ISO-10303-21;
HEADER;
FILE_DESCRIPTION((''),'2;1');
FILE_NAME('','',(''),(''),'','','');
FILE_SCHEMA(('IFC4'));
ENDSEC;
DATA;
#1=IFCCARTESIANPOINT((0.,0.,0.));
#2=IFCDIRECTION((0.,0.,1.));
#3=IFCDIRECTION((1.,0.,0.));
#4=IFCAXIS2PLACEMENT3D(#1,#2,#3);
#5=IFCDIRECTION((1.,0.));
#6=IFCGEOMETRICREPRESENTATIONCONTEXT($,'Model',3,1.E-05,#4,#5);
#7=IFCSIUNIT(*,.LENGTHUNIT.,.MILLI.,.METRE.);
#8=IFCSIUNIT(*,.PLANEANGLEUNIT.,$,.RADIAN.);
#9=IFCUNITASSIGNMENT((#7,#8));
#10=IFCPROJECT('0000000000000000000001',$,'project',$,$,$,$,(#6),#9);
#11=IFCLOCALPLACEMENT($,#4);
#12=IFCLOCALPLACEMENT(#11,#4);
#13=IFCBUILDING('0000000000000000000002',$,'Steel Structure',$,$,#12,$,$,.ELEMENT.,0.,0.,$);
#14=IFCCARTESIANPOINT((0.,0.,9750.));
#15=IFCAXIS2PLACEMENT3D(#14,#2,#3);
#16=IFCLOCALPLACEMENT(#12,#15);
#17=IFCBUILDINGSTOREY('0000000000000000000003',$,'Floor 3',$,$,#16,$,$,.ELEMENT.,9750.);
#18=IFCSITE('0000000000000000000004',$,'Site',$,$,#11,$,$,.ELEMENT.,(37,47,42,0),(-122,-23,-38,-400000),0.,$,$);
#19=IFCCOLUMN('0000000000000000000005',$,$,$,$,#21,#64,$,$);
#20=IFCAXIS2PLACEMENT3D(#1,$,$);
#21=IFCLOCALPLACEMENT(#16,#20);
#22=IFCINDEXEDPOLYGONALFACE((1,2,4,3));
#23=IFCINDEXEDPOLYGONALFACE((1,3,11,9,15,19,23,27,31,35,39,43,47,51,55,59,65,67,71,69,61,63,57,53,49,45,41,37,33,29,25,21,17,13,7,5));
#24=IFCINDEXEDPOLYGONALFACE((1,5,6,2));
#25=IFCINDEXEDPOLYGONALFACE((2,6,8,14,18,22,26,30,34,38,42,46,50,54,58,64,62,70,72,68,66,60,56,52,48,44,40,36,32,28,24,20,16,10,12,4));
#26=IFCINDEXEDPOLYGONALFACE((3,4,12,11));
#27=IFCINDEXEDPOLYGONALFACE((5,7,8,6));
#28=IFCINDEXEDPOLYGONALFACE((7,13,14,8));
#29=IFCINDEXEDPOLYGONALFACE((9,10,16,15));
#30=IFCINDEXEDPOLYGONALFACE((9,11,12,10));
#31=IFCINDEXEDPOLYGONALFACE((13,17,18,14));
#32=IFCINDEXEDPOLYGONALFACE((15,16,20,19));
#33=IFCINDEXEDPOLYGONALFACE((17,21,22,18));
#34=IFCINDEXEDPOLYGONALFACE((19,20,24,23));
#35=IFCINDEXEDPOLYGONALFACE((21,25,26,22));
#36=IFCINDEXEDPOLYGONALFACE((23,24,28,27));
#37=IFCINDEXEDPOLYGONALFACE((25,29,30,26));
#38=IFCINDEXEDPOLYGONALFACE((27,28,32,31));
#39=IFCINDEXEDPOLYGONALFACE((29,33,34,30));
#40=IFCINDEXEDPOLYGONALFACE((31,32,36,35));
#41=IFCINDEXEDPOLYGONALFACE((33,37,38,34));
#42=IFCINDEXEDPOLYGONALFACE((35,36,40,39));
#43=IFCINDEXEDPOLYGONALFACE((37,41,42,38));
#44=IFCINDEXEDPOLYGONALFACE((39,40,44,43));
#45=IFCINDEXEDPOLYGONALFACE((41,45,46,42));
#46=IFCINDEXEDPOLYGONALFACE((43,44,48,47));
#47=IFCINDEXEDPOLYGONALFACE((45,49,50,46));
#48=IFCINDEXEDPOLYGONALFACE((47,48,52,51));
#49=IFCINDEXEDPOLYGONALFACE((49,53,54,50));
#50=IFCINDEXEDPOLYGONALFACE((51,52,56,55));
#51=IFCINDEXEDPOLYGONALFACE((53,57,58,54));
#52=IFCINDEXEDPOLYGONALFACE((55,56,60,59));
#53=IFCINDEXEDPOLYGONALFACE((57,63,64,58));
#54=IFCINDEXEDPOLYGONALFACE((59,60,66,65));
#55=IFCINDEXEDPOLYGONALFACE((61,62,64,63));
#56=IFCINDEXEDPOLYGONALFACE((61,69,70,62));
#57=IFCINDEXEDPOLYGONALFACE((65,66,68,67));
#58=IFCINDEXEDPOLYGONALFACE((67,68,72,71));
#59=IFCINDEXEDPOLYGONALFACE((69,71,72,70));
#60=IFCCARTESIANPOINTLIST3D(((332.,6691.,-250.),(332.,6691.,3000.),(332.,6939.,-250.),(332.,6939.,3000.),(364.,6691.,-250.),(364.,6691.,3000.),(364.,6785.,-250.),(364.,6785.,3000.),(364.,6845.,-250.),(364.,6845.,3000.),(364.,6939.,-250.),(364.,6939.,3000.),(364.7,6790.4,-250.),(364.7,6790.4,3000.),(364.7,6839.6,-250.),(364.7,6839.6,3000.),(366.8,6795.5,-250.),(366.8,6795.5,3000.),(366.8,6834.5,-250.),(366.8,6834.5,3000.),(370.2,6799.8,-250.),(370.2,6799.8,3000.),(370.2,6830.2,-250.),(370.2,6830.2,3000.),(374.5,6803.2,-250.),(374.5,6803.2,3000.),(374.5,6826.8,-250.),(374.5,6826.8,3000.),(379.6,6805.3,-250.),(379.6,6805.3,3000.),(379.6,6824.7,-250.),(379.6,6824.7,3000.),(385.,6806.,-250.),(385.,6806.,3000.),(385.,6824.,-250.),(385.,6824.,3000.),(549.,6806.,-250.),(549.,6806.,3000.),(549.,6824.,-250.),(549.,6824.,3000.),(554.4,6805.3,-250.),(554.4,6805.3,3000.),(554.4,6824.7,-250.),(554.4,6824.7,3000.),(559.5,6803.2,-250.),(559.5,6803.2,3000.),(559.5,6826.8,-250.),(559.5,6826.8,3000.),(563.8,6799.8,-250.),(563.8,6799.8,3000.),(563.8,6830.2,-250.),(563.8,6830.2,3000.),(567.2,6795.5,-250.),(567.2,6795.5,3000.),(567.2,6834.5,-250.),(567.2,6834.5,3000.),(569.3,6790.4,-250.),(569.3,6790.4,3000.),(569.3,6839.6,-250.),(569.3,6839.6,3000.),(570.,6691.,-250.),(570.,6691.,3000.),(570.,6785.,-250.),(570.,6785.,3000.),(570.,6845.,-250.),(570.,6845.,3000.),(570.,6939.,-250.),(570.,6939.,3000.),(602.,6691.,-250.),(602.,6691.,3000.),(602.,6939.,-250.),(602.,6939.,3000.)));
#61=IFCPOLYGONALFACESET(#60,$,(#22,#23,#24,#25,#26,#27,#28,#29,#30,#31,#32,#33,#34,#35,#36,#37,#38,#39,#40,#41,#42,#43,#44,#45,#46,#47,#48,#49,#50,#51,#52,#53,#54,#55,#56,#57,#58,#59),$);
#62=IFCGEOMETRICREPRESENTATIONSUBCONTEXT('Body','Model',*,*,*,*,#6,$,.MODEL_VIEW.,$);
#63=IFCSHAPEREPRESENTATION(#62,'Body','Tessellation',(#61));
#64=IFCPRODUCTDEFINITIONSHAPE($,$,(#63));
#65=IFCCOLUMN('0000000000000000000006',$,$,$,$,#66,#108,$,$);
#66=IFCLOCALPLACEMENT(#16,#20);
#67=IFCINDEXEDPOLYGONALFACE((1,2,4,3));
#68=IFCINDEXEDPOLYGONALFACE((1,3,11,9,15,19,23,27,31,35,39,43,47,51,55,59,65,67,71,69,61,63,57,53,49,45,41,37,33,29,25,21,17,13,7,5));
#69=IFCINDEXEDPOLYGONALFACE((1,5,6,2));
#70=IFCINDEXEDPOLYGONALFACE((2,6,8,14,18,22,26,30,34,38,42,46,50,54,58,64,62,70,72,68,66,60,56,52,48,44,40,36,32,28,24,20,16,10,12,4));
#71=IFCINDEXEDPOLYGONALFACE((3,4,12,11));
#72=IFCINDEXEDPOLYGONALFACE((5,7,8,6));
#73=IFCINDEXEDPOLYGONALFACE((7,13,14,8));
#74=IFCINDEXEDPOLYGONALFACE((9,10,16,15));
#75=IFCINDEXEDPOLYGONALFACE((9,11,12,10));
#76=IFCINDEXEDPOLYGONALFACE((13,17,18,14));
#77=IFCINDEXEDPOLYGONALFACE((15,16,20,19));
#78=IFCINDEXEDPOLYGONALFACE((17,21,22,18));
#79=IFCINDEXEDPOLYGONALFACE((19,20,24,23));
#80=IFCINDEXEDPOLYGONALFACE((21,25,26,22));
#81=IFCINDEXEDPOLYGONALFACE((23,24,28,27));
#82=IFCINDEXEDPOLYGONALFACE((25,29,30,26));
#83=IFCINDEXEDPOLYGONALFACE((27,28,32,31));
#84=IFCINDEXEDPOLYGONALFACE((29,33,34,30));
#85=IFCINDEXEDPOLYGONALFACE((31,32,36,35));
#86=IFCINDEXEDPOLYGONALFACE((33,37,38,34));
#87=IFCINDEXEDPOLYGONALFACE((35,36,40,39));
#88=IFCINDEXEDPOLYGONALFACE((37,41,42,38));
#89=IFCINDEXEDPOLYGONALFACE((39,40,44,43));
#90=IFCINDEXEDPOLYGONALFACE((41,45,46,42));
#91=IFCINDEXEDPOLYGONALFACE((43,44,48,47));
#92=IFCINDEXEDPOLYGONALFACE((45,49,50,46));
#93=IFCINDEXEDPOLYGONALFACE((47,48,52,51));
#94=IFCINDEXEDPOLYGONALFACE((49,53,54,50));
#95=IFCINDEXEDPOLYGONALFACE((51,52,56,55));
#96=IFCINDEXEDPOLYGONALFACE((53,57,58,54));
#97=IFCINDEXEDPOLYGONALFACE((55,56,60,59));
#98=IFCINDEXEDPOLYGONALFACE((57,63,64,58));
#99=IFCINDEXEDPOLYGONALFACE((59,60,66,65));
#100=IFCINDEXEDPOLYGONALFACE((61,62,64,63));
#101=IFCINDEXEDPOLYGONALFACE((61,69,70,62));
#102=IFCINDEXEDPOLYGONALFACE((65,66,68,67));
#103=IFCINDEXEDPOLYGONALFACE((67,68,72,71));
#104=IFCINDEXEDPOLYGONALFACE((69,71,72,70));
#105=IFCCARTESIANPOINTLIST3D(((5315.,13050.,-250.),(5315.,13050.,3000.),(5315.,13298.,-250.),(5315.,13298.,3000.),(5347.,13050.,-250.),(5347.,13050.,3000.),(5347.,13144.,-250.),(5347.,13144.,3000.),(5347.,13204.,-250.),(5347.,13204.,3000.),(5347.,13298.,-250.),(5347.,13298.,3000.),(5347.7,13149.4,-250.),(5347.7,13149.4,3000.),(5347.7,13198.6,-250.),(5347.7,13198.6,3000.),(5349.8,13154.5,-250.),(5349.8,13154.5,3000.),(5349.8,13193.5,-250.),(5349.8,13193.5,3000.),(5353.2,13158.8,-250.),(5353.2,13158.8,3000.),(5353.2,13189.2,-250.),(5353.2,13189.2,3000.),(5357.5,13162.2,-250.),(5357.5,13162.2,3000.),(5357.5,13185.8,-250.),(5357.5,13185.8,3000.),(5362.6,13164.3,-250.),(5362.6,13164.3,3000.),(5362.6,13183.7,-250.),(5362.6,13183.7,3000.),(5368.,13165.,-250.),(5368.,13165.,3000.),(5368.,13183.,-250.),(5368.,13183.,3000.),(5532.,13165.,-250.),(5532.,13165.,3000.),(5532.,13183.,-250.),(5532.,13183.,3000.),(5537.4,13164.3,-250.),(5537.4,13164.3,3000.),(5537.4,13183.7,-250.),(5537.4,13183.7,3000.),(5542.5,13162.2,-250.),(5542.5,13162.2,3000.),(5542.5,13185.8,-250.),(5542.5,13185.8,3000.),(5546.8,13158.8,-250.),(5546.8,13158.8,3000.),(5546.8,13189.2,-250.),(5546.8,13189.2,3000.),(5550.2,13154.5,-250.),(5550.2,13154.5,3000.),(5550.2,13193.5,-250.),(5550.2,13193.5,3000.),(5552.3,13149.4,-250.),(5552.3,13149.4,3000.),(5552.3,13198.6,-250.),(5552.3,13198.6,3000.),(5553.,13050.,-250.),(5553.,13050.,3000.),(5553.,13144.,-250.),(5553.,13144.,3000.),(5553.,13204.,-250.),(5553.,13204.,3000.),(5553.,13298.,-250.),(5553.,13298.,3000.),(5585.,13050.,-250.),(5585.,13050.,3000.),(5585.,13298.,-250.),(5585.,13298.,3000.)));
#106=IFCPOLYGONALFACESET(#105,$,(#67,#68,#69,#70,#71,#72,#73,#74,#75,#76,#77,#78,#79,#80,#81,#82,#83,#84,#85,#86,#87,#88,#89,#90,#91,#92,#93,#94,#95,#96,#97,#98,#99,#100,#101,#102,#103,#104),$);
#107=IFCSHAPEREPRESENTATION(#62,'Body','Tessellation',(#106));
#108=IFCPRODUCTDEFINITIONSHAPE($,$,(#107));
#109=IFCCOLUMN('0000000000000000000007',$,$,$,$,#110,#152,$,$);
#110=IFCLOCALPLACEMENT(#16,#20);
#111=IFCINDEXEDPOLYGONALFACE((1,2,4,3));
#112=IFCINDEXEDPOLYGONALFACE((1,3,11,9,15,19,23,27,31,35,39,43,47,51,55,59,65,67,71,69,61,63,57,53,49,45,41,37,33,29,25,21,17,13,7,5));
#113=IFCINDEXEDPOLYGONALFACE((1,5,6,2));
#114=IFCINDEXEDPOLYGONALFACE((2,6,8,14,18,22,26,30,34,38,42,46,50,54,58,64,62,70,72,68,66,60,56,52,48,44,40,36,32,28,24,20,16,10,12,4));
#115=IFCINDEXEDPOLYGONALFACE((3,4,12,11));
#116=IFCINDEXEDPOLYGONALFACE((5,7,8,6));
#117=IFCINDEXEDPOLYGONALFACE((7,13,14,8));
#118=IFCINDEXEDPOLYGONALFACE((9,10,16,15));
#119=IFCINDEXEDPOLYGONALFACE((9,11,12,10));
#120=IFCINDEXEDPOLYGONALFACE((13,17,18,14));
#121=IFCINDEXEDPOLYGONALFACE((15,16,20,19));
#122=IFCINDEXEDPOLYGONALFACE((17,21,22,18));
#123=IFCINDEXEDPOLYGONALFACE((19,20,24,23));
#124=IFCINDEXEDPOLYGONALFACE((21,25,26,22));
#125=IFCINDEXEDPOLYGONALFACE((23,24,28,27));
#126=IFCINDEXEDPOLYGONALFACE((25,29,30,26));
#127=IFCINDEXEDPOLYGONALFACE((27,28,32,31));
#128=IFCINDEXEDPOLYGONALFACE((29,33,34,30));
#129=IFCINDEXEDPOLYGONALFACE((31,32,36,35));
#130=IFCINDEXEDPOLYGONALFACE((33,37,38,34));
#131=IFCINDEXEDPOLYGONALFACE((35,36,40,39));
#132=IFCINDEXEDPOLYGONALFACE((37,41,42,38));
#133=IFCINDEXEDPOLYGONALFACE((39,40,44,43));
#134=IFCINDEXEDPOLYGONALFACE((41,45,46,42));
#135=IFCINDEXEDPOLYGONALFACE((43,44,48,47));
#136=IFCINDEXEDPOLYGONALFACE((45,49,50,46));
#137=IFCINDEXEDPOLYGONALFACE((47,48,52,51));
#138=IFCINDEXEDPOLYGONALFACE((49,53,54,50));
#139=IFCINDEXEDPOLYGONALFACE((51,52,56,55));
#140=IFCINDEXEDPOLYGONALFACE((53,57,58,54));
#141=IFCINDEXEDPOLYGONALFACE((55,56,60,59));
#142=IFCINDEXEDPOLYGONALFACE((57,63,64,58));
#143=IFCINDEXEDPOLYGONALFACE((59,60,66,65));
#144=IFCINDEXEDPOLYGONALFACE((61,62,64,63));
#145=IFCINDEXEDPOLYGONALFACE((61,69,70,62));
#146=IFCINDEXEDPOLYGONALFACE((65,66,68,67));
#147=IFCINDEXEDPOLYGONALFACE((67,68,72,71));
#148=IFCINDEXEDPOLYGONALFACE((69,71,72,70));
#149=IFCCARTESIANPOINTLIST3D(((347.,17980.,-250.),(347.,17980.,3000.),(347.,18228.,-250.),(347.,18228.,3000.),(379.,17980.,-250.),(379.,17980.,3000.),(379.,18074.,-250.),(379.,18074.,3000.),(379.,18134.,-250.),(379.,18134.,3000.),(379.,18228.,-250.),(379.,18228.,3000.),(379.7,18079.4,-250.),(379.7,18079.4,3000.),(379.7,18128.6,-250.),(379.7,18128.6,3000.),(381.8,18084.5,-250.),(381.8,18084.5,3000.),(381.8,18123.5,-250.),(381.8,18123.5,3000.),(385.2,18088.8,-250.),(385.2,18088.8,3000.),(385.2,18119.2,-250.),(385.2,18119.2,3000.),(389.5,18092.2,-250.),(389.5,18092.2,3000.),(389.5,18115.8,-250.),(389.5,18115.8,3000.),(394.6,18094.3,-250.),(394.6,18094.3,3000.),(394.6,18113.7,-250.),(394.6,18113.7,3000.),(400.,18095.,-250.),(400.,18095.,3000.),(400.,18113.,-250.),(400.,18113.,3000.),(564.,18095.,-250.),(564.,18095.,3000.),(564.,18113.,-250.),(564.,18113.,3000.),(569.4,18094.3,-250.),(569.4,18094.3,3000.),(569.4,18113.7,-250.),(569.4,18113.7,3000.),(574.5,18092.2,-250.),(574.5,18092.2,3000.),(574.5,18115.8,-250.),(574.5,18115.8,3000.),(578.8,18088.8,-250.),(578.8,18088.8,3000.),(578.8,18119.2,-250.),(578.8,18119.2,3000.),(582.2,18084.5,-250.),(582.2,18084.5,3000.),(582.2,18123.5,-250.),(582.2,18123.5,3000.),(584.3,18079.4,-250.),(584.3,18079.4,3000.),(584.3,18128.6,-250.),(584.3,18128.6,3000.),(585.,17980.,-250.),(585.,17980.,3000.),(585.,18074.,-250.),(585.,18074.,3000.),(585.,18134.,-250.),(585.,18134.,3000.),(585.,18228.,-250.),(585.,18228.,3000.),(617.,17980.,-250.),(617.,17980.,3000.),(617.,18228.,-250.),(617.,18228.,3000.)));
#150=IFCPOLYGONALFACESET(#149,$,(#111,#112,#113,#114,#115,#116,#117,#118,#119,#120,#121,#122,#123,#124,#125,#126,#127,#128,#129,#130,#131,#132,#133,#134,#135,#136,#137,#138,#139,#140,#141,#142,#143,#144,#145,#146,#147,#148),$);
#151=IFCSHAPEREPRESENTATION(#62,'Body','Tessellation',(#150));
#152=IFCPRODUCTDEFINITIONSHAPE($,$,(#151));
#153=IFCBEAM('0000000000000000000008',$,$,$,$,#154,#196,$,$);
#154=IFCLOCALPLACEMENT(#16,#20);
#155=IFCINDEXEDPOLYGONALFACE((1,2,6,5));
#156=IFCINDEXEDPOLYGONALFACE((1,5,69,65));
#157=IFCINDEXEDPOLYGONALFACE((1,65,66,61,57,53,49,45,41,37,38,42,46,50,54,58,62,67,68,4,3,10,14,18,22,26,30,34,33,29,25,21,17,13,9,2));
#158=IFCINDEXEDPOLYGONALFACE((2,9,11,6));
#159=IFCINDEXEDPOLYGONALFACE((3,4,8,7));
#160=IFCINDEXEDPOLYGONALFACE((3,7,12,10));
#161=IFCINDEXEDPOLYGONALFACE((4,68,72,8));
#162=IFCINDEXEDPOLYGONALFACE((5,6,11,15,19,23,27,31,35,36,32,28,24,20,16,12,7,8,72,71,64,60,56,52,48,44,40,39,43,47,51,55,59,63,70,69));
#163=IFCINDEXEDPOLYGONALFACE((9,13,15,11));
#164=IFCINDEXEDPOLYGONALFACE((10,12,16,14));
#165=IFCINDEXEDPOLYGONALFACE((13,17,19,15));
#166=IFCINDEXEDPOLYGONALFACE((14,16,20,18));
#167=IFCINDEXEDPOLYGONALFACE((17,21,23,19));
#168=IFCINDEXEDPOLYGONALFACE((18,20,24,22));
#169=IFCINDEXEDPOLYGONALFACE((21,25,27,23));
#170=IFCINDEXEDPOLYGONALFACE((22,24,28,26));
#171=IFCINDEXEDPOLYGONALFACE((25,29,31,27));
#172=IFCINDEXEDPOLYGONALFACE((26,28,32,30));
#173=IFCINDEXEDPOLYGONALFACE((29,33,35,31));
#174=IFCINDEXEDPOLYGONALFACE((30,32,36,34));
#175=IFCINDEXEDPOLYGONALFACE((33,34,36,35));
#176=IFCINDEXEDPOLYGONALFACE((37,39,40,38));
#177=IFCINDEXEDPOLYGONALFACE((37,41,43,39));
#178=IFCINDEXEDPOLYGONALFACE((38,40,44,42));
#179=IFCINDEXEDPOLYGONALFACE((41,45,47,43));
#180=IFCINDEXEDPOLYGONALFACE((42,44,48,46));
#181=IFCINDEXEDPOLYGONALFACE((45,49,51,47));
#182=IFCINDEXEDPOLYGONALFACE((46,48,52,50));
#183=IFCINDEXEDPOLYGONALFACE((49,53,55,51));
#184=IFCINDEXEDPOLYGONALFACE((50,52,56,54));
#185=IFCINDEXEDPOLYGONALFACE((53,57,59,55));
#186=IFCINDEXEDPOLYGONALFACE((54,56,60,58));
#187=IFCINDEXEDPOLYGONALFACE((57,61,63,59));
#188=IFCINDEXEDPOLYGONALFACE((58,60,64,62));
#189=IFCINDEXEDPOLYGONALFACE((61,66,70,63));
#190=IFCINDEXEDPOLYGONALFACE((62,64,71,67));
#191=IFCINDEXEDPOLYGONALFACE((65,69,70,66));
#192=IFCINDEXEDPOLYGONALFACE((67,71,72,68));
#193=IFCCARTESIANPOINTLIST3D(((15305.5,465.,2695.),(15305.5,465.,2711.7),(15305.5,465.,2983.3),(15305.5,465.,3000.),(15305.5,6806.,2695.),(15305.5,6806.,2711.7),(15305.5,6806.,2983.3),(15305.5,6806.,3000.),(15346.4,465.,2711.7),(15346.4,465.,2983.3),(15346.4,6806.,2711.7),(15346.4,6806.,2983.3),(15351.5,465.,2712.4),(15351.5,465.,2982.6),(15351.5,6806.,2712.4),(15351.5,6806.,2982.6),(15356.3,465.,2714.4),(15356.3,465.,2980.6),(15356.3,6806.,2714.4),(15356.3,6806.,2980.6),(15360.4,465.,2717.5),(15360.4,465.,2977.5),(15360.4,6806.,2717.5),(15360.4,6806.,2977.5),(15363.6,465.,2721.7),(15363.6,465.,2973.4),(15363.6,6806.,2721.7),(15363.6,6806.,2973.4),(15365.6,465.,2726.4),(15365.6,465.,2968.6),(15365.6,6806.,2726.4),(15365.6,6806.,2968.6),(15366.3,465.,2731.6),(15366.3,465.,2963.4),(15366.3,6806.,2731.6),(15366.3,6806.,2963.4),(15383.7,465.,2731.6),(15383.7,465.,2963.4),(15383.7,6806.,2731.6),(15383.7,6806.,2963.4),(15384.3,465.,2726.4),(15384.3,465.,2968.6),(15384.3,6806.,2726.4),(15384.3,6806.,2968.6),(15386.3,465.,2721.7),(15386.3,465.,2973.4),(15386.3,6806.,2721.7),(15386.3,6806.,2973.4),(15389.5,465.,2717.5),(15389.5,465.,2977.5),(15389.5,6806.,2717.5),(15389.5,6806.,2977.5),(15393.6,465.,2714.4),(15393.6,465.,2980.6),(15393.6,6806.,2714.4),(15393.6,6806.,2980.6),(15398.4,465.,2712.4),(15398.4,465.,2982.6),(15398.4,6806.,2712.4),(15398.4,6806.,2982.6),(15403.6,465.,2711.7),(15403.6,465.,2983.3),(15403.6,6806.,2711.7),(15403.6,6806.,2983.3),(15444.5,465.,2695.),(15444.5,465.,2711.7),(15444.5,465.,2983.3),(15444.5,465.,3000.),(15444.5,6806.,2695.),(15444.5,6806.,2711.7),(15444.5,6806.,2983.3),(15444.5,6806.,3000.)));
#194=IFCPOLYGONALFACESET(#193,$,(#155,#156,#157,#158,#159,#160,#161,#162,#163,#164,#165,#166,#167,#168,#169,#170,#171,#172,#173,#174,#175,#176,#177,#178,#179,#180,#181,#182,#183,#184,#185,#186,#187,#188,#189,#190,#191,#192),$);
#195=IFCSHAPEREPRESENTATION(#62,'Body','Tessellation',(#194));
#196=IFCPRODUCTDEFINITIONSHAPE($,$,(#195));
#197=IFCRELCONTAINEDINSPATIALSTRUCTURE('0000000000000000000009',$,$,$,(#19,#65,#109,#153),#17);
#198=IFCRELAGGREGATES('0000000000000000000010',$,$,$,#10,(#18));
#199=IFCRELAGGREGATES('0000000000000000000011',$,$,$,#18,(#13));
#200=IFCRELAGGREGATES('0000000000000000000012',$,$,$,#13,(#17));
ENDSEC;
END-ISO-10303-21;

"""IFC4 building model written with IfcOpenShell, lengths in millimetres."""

from ifc_helpers import new_model, si_unit, direction, frame, origin_with_axes, origin_2d_with_axis, place, context, subcontext, project, spatial, i_section, extrude, element, save


model = new_model("IFC4")

# Units and contexts
model_context = context("Model", 3, precision=1e-05, world=origin_with_axes(), true_north=direction((1.0, 0.0)))
body_context = subcontext(model_context, "Body", "Model", "MODEL_VIEW")
ifc_project = project(units=[si_unit("LENGTHUNIT", "METRE", prefix="MILLI"), si_unit("PLANEANGLEUNIT", "RADIAN")], contexts=[model_context])

# Site, building, storey
site_placement = place(None, origin_with_axes())
site = spatial("IfcSite", under=ifc_project, at=site_placement, Name="Site", CompositionType="ELEMENT", RefLatitude=(37, 47, 42, 0), RefLongitude=(-122, -23, -38, -400000), RefElevation=0.0)
building_placement = place(site_placement, origin_with_axes())
building = spatial("IfcBuilding", under=site, at=building_placement, Name="Steel Structure", CompositionType="ELEMENT", ElevationOfRefHeight=0.0, ElevationOfTerrain=0.0)
storey_placement = place(building_placement, frame((0.0, 0.0, 9750.0), z_axis=(0.0, 0.0, 1.0), x_axis=(1.0, 0.0, 0.0)))
storey = spatial("IfcBuildingStorey", under=building, at=storey_placement, Name="Floor 3", CompositionType="ELEMENT", Elevation=9750.0)

# Columns
for number, where, z_axis, x_axis in (
    (1, (467.0, 6815.0, -250.0), (0.0, 0.0, 1.0), (0.0, -1.0, 0.0)),
):
    element("IfcColumn", number, at=place(storey_placement, frame(where, z_axis=z_axis, x_axis=x_axis)), inside=storey, context=body_context, shape_type="SweptSolid", body=[
        extrude(i_section(OverallWidth=248.0, OverallDepth=270.0, WebThickness=18.0, FlangeThickness=32.0, FilletRadius=21.0, at=origin_2d_with_axis()), origin_with_axes(), (0.0, 0.0, 1.0), 3250.0),
    ])
for number, where, z_axis, x_axis in (
    (2, (5450.0, 13174.0, -250.0), (0.0, 0.0, 1.0), (0.0, -1.0, 0.0)),
    (3, (482.0, 18104.0, -250.0), (0.0, 0.0, 1.0), (0.0, -1.0, 0.0)),
):
    element("IfcColumn", number, at=place(storey_placement, frame(where, z_axis=z_axis, x_axis=x_axis)), inside=storey, context=body_context, shape_type="SweptSolid", body=[
        extrude(i_section(OverallWidth=248.0, OverallDepth=270.0, WebThickness=18.0, FlangeThickness=32.0, FilletRadius=21.0, at=origin_2d_with_axis()), origin_with_axes(), (0.0, 0.0, 1.0), 3250.0),
    ])

# Beam
for number, where, z_axis, x_axis in (
    (4, (15375.0, 6806.0, 2847.5), (0.0, -1.0, 0.0), (1.0, 0.0, 0.0)),
):
    element("IfcBeam", number, at=place(storey_placement, frame(where, z_axis=z_axis, x_axis=x_axis)), inside=storey, context=body_context, shape_type="SweptSolid", body=[
        extrude(i_section(OverallWidth=139.0, OverallDepth=305.0, WebThickness=17.4, FlangeThickness=16.7, FilletRadius=19.9, at=origin_2d_with_axis()), origin_with_axes(), (0.0, 0.0, 1.0), 6341.0),
    ])

save(model, "model.ifc")
